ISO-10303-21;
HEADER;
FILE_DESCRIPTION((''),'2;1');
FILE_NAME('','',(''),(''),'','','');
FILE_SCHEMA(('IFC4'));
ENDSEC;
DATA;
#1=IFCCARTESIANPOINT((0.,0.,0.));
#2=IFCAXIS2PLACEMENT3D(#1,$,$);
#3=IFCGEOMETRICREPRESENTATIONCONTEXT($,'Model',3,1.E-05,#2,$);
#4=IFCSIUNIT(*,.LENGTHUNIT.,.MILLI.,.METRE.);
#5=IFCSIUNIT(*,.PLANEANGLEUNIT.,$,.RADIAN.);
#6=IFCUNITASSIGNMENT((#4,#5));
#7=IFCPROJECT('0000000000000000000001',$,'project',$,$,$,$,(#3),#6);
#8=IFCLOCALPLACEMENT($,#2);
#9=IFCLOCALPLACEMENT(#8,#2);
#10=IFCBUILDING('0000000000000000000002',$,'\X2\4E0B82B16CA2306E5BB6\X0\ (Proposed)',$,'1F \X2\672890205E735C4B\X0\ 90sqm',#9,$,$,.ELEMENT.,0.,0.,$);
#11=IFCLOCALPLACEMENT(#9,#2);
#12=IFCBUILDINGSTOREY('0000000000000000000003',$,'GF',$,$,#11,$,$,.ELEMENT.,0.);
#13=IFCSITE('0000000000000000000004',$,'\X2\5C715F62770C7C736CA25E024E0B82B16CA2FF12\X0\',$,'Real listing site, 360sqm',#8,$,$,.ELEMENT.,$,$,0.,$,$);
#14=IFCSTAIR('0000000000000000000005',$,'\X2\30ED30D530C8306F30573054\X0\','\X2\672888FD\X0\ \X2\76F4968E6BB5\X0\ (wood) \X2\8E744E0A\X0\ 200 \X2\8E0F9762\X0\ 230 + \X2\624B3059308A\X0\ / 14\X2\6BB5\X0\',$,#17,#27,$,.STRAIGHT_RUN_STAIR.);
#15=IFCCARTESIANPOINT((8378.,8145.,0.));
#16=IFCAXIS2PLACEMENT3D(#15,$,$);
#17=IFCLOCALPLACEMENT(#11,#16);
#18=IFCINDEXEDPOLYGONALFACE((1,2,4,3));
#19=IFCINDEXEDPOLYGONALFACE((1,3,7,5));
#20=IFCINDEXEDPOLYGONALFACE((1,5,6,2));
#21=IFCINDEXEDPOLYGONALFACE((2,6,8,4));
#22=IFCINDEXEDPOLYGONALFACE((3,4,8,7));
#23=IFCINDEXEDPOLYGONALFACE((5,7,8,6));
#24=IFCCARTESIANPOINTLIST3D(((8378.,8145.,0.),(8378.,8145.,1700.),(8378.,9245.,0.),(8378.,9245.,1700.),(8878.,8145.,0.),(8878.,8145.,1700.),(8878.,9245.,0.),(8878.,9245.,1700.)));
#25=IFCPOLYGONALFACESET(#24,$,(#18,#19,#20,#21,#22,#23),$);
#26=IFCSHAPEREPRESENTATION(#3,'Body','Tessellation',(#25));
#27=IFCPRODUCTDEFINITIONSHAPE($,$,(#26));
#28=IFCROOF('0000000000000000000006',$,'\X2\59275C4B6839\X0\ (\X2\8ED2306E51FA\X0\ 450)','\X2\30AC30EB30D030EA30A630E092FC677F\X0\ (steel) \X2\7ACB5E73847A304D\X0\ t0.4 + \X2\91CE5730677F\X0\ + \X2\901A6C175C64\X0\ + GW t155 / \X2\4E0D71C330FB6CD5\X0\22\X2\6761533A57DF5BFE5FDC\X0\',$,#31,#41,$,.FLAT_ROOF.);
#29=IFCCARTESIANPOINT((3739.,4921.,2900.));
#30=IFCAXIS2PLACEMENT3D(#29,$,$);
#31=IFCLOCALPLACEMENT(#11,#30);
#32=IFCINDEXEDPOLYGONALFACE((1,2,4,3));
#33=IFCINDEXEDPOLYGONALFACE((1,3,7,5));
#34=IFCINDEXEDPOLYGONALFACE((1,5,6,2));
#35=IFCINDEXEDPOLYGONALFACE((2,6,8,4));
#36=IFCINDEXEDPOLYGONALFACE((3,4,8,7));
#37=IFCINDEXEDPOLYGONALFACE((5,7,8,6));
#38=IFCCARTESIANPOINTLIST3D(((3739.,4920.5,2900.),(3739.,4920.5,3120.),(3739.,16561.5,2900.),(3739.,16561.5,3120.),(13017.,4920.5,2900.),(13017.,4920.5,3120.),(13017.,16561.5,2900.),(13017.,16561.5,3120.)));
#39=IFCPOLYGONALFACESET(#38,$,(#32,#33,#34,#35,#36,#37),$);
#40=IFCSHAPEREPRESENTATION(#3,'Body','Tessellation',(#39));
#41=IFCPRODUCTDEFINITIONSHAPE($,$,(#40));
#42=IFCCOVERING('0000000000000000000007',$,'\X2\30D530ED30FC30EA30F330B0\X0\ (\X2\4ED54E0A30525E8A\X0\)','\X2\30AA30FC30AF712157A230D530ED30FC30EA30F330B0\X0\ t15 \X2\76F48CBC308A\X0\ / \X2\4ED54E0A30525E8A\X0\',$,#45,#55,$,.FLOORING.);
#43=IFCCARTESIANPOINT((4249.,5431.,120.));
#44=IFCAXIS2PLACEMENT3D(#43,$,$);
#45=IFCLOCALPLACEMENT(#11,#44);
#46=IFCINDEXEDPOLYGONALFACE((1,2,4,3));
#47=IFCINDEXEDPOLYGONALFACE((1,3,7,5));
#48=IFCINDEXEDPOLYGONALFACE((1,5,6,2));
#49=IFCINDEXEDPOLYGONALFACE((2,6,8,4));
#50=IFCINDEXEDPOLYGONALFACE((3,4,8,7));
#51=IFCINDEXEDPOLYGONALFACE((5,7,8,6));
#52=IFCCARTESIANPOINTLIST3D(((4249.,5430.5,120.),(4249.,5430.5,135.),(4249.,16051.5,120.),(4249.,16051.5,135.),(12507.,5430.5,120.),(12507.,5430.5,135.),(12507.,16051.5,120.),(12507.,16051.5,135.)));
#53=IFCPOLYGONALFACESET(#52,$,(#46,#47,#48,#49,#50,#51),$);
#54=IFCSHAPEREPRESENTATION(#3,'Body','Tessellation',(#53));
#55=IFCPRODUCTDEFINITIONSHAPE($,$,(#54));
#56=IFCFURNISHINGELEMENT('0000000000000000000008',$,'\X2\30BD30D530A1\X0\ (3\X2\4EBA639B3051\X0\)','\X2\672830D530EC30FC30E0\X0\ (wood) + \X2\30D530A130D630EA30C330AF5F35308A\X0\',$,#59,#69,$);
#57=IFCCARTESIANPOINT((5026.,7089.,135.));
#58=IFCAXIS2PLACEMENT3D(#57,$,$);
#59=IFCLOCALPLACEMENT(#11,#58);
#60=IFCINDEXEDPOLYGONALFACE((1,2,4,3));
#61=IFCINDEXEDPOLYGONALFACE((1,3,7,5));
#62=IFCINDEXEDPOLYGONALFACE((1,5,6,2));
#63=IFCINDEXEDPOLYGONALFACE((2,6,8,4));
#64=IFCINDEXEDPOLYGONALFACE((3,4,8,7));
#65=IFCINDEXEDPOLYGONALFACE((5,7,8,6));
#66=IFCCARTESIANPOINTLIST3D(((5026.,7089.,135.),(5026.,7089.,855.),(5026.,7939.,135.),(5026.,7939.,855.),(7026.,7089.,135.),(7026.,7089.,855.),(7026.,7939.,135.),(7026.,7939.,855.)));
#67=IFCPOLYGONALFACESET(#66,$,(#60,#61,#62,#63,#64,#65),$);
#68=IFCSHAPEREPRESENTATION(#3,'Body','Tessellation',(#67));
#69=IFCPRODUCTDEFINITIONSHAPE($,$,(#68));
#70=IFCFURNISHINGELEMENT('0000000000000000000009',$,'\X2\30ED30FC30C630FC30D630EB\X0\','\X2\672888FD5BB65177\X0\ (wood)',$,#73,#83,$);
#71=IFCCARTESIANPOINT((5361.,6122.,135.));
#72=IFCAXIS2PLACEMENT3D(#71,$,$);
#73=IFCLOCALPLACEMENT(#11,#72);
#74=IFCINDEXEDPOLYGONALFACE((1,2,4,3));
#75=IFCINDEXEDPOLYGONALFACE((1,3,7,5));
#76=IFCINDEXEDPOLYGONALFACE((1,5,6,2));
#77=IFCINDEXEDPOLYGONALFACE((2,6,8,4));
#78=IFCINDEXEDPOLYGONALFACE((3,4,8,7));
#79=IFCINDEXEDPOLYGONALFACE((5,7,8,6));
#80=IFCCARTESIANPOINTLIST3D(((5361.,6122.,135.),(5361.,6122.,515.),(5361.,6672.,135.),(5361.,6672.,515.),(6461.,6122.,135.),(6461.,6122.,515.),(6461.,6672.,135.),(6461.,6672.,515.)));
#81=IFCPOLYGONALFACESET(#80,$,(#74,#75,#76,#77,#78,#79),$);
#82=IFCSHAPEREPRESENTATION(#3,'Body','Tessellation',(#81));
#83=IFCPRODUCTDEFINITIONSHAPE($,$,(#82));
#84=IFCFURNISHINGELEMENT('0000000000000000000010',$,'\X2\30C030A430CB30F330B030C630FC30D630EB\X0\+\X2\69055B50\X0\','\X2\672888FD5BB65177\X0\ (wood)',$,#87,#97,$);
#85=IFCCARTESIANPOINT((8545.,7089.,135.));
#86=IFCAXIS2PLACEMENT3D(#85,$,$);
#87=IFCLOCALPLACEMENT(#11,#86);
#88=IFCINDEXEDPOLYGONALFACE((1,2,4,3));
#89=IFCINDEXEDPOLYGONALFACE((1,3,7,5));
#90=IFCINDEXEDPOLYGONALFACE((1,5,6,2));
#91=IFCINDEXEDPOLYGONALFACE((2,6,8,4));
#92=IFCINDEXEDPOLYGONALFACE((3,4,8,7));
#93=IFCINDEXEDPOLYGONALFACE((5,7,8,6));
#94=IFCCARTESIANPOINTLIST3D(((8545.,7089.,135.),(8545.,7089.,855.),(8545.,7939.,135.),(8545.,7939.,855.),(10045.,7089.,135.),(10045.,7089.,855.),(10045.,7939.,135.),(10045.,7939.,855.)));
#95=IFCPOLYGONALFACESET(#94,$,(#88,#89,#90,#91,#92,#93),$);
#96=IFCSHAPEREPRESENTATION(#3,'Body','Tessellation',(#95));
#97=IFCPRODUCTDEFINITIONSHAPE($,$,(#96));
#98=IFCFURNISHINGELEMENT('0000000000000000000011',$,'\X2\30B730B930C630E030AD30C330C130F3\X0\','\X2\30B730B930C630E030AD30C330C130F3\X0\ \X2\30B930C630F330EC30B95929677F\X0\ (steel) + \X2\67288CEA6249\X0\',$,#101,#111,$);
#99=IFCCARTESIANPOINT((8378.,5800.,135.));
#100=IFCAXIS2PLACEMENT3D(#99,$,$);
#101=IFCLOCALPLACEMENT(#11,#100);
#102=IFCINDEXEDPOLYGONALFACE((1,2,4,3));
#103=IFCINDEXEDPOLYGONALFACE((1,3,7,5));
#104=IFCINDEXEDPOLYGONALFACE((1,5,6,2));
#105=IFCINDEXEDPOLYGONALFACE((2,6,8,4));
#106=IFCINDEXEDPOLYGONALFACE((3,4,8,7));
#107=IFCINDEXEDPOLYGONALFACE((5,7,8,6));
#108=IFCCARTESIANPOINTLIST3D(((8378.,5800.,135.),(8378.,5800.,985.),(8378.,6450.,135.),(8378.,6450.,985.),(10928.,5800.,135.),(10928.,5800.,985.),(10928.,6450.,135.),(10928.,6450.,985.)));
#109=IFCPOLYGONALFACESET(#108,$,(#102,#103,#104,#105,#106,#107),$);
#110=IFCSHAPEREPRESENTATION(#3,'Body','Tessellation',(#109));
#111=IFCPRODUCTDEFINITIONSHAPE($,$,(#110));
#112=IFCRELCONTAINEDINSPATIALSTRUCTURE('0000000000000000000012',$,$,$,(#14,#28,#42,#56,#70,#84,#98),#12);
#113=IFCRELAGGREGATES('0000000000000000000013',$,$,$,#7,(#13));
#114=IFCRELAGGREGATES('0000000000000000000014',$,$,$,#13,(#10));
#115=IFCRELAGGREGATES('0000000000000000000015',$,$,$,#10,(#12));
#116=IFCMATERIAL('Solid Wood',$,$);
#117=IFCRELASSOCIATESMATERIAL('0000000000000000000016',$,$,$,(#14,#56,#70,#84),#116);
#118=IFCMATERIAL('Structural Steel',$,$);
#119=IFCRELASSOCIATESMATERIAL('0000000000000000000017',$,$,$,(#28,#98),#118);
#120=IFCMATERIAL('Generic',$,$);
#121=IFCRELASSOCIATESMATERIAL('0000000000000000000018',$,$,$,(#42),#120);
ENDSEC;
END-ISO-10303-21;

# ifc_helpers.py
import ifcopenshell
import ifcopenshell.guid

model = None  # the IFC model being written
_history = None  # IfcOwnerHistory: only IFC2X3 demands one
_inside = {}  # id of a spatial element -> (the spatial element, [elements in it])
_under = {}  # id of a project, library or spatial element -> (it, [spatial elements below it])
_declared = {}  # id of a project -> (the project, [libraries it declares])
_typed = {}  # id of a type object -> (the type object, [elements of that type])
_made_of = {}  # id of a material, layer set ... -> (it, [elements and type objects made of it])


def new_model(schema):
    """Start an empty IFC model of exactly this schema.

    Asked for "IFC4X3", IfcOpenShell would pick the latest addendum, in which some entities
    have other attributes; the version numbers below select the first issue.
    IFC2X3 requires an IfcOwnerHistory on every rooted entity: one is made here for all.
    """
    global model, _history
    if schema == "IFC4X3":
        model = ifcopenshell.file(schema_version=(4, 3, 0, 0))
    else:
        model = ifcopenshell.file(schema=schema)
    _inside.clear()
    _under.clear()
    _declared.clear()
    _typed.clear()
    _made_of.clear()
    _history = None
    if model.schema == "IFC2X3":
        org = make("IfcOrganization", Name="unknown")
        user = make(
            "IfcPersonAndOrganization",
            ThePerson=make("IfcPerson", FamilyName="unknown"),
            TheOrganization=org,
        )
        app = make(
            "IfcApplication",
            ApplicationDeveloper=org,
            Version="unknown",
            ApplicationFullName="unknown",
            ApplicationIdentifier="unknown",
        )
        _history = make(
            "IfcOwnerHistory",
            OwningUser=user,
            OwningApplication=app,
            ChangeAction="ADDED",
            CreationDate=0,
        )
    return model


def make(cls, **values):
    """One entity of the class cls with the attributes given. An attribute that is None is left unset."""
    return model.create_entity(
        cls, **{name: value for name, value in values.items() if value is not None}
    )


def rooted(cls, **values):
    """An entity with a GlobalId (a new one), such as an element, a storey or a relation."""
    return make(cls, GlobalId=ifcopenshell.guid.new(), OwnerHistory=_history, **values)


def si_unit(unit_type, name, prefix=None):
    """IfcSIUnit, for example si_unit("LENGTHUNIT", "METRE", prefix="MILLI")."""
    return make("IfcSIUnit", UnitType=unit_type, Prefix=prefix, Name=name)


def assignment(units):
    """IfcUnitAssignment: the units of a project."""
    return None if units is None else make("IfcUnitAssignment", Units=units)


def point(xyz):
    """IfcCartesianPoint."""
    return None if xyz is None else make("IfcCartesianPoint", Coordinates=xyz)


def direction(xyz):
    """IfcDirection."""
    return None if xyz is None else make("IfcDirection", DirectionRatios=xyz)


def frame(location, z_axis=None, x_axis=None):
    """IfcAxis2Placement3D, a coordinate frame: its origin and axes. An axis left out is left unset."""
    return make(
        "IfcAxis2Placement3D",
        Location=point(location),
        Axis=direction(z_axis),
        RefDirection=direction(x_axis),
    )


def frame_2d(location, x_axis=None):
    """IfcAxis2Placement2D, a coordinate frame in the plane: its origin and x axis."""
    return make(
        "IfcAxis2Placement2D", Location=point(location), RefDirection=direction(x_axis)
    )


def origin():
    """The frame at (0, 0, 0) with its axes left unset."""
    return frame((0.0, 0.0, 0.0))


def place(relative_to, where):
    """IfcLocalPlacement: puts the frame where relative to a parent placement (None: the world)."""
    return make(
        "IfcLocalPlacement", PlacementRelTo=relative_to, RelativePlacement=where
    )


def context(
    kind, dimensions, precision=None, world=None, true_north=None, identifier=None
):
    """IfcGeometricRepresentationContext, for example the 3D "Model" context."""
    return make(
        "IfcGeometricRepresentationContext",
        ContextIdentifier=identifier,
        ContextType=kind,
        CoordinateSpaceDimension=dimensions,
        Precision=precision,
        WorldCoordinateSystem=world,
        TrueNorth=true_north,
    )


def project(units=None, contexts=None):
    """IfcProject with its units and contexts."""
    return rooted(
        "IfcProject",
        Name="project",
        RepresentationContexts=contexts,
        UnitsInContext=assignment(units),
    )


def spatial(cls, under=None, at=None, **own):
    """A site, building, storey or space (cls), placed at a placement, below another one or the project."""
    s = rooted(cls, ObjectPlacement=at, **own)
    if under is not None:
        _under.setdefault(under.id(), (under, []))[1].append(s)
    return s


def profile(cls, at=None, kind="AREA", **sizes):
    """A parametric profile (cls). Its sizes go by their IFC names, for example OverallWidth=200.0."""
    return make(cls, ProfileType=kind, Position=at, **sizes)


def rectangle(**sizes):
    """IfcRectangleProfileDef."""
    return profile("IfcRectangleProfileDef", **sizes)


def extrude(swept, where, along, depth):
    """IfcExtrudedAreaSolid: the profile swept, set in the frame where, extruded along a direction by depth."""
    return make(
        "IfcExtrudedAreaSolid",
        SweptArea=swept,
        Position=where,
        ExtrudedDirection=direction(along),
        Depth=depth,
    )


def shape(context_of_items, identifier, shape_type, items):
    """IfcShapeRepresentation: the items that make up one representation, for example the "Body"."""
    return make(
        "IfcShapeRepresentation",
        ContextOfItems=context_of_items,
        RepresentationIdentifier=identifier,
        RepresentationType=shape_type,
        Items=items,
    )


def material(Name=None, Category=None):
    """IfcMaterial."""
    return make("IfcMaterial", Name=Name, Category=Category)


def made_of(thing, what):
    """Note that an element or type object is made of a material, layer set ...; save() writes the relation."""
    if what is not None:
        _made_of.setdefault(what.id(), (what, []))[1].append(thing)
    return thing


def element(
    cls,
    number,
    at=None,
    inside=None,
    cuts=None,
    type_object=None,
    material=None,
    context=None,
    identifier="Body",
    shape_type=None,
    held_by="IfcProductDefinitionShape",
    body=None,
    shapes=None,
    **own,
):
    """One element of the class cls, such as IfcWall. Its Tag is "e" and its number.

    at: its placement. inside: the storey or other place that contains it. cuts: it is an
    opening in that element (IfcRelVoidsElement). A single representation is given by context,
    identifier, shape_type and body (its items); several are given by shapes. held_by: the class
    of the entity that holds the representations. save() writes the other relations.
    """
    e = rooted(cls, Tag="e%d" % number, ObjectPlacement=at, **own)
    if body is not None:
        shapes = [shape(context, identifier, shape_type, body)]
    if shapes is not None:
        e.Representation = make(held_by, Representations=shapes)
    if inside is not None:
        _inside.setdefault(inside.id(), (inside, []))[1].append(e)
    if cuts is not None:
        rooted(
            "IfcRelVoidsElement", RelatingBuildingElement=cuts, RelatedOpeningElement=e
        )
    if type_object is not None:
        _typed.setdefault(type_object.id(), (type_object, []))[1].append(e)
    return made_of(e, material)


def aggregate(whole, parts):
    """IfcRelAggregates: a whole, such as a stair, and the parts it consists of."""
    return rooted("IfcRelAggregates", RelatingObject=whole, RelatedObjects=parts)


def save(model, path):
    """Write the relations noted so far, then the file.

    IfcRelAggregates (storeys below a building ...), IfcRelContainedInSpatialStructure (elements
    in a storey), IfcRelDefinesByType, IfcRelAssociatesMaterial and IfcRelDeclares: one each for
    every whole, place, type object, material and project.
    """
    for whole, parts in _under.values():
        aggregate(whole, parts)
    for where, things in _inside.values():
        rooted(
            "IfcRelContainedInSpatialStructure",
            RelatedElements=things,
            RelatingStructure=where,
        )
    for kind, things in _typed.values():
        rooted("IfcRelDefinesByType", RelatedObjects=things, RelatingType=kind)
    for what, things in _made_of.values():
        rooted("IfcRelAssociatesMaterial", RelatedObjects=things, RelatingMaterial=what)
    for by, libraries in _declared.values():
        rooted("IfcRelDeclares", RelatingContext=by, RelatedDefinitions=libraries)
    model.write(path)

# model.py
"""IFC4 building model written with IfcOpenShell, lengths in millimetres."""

from ifc_helpers import new_model, si_unit, frame, frame_2d, origin, place, context, project, spatial, rectangle, extrude, material, element, save


model = new_model("IFC4")

# Units and contexts
model_context = context("Model", 3, precision=1e-05, world=origin())
ifc_project = project(units=[si_unit("LENGTHUNIT", "METRE", prefix="MILLI"), si_unit("PLANEANGLEUNIT", "RADIAN")], contexts=[model_context])

# Site, building, storey
site_placement = place(None, origin())
site = spatial("IfcSite", under=ifc_project, at=site_placement, Name="山形県米沢市下花沢２", ObjectType="Real listing site, 360sqm", CompositionType="ELEMENT", RefElevation=0.0)
building_placement = place(site_placement, origin())
building = spatial("IfcBuilding", under=site, at=building_placement, Name="下花沢の家 (Proposed)", ObjectType="1F 木造平屋 90sqm", CompositionType="ELEMENT", ElevationOfRefHeight=0.0, ElevationOfTerrain=0.0)
storey_placement = place(building_placement, origin())
storey = spatial("IfcBuildingStorey", under=building, at=storey_placement, Name="GF", CompositionType="ELEMENT", Elevation=0.0)

# Shared definitions
ifc_material_1 = material(Name="Solid Wood")

# Stair
stair_placement = place(storey_placement, frame((8378.0, 8145.0, 0.0)))
element("IfcStair", 1, at=stair_placement, inside=storey, material=ifc_material_1, Name="ロフトはしご", Description="木製 直階段 (wood) 蹴上 200 踏面 230 + 手すり / 14段", PredefinedType="STRAIGHT_RUN_STAIR", context=model_context, shape_type="SweptSolid", body=[
    extrude(rectangle(XDim=500.0, YDim=1100.0, at=frame_2d((250.0, 550.0))), frame((8378.0, 8145.0, 0.0)), (0.0, 0.0, 1.0), 1700.0),
])

# Roof
ifc_material_2 = material(Name="Structural Steel")
roof_placement = place(storey_placement, frame((3739.0, 4921.0, 2900.0)))
element("IfcRoof", 2, at=roof_placement, inside=storey, material=ifc_material_2, Name="大屋根 (軒の出 450)", Description="ガルバリウム鋼板 (steel) 立平葺き t0.4 + 野地板 + 通気層 + GW t155 / 不燃・法22条区域対応", PredefinedType="FLAT_ROOF", context=model_context, shape_type="SweptSolid", body=[
    extrude(rectangle(XDim=9278.0, YDim=11641.0, at=frame_2d((4639.0, 5820.0))), frame((3739.0, 4921.0, 2900.0)), (0.0, 0.0, 1.0), 220.0),
])

# Covering
ifc_material_3 = material(Name="Generic")
covering_placement = place(storey_placement, frame((4249.0, 5431.0, 120.0)))
element("IfcCovering", 3, at=covering_placement, inside=storey, material=ifc_material_3, Name="フローリング (仕上げ床)", Description="オーク無垢フローリング t15 直貼り / 仕上げ床", PredefinedType="FLOORING", context=model_context, shape_type="SweptSolid", body=[
    extrude(rectangle(XDim=8258.0, YDim=10621.0, at=frame_2d((4129.0, 5310.0))), frame((4249.0, 5431.0, 120.0)), (0.0, 0.0, 1.0), 15.0),
])

# Furnishing elements
furnishing_1_placement = place(storey_placement, frame((5026.0, 7089.0, 135.0)))
element("IfcFurnishingElement", 4, at=furnishing_1_placement, inside=storey, material=ifc_material_1, Name="ソファ (3人掛け)", Description="木フレーム (wood) + ファブリック張り", context=model_context, shape_type="SweptSolid", body=[
    extrude(rectangle(XDim=2000.0, YDim=850.0, at=frame_2d((1000.0, 425.0))), frame((5026.0, 7089.0, 135.0)), (0.0, 0.0, 1.0), 720.0),
])
furnishing_2_placement = place(storey_placement, frame((5361.0, 6122.0, 135.0)))
element("IfcFurnishingElement", 5, at=furnishing_2_placement, inside=storey, material=ifc_material_1, Name="ローテーブル", Description="木製家具 (wood)", context=model_context, shape_type="SweptSolid", body=[
    extrude(rectangle(XDim=1100.0, YDim=550.0, at=frame_2d((550.0, 275.0))), frame((5361.0, 6122.0, 135.0)), (0.0, 0.0, 1.0), 380.0),
])
furnishing_3_placement = place(storey_placement, frame((8545.0, 7089.0, 135.0)))
element("IfcFurnishingElement", 6, at=furnishing_3_placement, inside=storey, material=ifc_material_1, Name="ダイニングテーブル+椅子", Description="木製家具 (wood)", context=model_context, shape_type="SweptSolid", body=[
    extrude(rectangle(XDim=1500.0, YDim=850.0, at=frame_2d((750.0, 425.0))), frame((8545.0, 7089.0, 135.0)), (0.0, 0.0, 1.0), 720.0),
])
furnishing_4_placement = place(storey_placement, frame((8378.0, 5800.0, 135.0)))
element("IfcFurnishingElement", 7, at=furnishing_4_placement, inside=storey, material=ifc_material_2, Name="システムキッチン", Description="システムキッチン ステンレス天板 (steel) + 木質扉", context=model_context, shape_type="SweptSolid", body=[
    extrude(rectangle(XDim=2550.0, YDim=650.0, at=frame_2d((1275.0, 325.0))), frame((8378.0, 5800.0, 135.0)), (0.0, 0.0, 1.0), 850.0),
])

save(model, "model.ifc")
